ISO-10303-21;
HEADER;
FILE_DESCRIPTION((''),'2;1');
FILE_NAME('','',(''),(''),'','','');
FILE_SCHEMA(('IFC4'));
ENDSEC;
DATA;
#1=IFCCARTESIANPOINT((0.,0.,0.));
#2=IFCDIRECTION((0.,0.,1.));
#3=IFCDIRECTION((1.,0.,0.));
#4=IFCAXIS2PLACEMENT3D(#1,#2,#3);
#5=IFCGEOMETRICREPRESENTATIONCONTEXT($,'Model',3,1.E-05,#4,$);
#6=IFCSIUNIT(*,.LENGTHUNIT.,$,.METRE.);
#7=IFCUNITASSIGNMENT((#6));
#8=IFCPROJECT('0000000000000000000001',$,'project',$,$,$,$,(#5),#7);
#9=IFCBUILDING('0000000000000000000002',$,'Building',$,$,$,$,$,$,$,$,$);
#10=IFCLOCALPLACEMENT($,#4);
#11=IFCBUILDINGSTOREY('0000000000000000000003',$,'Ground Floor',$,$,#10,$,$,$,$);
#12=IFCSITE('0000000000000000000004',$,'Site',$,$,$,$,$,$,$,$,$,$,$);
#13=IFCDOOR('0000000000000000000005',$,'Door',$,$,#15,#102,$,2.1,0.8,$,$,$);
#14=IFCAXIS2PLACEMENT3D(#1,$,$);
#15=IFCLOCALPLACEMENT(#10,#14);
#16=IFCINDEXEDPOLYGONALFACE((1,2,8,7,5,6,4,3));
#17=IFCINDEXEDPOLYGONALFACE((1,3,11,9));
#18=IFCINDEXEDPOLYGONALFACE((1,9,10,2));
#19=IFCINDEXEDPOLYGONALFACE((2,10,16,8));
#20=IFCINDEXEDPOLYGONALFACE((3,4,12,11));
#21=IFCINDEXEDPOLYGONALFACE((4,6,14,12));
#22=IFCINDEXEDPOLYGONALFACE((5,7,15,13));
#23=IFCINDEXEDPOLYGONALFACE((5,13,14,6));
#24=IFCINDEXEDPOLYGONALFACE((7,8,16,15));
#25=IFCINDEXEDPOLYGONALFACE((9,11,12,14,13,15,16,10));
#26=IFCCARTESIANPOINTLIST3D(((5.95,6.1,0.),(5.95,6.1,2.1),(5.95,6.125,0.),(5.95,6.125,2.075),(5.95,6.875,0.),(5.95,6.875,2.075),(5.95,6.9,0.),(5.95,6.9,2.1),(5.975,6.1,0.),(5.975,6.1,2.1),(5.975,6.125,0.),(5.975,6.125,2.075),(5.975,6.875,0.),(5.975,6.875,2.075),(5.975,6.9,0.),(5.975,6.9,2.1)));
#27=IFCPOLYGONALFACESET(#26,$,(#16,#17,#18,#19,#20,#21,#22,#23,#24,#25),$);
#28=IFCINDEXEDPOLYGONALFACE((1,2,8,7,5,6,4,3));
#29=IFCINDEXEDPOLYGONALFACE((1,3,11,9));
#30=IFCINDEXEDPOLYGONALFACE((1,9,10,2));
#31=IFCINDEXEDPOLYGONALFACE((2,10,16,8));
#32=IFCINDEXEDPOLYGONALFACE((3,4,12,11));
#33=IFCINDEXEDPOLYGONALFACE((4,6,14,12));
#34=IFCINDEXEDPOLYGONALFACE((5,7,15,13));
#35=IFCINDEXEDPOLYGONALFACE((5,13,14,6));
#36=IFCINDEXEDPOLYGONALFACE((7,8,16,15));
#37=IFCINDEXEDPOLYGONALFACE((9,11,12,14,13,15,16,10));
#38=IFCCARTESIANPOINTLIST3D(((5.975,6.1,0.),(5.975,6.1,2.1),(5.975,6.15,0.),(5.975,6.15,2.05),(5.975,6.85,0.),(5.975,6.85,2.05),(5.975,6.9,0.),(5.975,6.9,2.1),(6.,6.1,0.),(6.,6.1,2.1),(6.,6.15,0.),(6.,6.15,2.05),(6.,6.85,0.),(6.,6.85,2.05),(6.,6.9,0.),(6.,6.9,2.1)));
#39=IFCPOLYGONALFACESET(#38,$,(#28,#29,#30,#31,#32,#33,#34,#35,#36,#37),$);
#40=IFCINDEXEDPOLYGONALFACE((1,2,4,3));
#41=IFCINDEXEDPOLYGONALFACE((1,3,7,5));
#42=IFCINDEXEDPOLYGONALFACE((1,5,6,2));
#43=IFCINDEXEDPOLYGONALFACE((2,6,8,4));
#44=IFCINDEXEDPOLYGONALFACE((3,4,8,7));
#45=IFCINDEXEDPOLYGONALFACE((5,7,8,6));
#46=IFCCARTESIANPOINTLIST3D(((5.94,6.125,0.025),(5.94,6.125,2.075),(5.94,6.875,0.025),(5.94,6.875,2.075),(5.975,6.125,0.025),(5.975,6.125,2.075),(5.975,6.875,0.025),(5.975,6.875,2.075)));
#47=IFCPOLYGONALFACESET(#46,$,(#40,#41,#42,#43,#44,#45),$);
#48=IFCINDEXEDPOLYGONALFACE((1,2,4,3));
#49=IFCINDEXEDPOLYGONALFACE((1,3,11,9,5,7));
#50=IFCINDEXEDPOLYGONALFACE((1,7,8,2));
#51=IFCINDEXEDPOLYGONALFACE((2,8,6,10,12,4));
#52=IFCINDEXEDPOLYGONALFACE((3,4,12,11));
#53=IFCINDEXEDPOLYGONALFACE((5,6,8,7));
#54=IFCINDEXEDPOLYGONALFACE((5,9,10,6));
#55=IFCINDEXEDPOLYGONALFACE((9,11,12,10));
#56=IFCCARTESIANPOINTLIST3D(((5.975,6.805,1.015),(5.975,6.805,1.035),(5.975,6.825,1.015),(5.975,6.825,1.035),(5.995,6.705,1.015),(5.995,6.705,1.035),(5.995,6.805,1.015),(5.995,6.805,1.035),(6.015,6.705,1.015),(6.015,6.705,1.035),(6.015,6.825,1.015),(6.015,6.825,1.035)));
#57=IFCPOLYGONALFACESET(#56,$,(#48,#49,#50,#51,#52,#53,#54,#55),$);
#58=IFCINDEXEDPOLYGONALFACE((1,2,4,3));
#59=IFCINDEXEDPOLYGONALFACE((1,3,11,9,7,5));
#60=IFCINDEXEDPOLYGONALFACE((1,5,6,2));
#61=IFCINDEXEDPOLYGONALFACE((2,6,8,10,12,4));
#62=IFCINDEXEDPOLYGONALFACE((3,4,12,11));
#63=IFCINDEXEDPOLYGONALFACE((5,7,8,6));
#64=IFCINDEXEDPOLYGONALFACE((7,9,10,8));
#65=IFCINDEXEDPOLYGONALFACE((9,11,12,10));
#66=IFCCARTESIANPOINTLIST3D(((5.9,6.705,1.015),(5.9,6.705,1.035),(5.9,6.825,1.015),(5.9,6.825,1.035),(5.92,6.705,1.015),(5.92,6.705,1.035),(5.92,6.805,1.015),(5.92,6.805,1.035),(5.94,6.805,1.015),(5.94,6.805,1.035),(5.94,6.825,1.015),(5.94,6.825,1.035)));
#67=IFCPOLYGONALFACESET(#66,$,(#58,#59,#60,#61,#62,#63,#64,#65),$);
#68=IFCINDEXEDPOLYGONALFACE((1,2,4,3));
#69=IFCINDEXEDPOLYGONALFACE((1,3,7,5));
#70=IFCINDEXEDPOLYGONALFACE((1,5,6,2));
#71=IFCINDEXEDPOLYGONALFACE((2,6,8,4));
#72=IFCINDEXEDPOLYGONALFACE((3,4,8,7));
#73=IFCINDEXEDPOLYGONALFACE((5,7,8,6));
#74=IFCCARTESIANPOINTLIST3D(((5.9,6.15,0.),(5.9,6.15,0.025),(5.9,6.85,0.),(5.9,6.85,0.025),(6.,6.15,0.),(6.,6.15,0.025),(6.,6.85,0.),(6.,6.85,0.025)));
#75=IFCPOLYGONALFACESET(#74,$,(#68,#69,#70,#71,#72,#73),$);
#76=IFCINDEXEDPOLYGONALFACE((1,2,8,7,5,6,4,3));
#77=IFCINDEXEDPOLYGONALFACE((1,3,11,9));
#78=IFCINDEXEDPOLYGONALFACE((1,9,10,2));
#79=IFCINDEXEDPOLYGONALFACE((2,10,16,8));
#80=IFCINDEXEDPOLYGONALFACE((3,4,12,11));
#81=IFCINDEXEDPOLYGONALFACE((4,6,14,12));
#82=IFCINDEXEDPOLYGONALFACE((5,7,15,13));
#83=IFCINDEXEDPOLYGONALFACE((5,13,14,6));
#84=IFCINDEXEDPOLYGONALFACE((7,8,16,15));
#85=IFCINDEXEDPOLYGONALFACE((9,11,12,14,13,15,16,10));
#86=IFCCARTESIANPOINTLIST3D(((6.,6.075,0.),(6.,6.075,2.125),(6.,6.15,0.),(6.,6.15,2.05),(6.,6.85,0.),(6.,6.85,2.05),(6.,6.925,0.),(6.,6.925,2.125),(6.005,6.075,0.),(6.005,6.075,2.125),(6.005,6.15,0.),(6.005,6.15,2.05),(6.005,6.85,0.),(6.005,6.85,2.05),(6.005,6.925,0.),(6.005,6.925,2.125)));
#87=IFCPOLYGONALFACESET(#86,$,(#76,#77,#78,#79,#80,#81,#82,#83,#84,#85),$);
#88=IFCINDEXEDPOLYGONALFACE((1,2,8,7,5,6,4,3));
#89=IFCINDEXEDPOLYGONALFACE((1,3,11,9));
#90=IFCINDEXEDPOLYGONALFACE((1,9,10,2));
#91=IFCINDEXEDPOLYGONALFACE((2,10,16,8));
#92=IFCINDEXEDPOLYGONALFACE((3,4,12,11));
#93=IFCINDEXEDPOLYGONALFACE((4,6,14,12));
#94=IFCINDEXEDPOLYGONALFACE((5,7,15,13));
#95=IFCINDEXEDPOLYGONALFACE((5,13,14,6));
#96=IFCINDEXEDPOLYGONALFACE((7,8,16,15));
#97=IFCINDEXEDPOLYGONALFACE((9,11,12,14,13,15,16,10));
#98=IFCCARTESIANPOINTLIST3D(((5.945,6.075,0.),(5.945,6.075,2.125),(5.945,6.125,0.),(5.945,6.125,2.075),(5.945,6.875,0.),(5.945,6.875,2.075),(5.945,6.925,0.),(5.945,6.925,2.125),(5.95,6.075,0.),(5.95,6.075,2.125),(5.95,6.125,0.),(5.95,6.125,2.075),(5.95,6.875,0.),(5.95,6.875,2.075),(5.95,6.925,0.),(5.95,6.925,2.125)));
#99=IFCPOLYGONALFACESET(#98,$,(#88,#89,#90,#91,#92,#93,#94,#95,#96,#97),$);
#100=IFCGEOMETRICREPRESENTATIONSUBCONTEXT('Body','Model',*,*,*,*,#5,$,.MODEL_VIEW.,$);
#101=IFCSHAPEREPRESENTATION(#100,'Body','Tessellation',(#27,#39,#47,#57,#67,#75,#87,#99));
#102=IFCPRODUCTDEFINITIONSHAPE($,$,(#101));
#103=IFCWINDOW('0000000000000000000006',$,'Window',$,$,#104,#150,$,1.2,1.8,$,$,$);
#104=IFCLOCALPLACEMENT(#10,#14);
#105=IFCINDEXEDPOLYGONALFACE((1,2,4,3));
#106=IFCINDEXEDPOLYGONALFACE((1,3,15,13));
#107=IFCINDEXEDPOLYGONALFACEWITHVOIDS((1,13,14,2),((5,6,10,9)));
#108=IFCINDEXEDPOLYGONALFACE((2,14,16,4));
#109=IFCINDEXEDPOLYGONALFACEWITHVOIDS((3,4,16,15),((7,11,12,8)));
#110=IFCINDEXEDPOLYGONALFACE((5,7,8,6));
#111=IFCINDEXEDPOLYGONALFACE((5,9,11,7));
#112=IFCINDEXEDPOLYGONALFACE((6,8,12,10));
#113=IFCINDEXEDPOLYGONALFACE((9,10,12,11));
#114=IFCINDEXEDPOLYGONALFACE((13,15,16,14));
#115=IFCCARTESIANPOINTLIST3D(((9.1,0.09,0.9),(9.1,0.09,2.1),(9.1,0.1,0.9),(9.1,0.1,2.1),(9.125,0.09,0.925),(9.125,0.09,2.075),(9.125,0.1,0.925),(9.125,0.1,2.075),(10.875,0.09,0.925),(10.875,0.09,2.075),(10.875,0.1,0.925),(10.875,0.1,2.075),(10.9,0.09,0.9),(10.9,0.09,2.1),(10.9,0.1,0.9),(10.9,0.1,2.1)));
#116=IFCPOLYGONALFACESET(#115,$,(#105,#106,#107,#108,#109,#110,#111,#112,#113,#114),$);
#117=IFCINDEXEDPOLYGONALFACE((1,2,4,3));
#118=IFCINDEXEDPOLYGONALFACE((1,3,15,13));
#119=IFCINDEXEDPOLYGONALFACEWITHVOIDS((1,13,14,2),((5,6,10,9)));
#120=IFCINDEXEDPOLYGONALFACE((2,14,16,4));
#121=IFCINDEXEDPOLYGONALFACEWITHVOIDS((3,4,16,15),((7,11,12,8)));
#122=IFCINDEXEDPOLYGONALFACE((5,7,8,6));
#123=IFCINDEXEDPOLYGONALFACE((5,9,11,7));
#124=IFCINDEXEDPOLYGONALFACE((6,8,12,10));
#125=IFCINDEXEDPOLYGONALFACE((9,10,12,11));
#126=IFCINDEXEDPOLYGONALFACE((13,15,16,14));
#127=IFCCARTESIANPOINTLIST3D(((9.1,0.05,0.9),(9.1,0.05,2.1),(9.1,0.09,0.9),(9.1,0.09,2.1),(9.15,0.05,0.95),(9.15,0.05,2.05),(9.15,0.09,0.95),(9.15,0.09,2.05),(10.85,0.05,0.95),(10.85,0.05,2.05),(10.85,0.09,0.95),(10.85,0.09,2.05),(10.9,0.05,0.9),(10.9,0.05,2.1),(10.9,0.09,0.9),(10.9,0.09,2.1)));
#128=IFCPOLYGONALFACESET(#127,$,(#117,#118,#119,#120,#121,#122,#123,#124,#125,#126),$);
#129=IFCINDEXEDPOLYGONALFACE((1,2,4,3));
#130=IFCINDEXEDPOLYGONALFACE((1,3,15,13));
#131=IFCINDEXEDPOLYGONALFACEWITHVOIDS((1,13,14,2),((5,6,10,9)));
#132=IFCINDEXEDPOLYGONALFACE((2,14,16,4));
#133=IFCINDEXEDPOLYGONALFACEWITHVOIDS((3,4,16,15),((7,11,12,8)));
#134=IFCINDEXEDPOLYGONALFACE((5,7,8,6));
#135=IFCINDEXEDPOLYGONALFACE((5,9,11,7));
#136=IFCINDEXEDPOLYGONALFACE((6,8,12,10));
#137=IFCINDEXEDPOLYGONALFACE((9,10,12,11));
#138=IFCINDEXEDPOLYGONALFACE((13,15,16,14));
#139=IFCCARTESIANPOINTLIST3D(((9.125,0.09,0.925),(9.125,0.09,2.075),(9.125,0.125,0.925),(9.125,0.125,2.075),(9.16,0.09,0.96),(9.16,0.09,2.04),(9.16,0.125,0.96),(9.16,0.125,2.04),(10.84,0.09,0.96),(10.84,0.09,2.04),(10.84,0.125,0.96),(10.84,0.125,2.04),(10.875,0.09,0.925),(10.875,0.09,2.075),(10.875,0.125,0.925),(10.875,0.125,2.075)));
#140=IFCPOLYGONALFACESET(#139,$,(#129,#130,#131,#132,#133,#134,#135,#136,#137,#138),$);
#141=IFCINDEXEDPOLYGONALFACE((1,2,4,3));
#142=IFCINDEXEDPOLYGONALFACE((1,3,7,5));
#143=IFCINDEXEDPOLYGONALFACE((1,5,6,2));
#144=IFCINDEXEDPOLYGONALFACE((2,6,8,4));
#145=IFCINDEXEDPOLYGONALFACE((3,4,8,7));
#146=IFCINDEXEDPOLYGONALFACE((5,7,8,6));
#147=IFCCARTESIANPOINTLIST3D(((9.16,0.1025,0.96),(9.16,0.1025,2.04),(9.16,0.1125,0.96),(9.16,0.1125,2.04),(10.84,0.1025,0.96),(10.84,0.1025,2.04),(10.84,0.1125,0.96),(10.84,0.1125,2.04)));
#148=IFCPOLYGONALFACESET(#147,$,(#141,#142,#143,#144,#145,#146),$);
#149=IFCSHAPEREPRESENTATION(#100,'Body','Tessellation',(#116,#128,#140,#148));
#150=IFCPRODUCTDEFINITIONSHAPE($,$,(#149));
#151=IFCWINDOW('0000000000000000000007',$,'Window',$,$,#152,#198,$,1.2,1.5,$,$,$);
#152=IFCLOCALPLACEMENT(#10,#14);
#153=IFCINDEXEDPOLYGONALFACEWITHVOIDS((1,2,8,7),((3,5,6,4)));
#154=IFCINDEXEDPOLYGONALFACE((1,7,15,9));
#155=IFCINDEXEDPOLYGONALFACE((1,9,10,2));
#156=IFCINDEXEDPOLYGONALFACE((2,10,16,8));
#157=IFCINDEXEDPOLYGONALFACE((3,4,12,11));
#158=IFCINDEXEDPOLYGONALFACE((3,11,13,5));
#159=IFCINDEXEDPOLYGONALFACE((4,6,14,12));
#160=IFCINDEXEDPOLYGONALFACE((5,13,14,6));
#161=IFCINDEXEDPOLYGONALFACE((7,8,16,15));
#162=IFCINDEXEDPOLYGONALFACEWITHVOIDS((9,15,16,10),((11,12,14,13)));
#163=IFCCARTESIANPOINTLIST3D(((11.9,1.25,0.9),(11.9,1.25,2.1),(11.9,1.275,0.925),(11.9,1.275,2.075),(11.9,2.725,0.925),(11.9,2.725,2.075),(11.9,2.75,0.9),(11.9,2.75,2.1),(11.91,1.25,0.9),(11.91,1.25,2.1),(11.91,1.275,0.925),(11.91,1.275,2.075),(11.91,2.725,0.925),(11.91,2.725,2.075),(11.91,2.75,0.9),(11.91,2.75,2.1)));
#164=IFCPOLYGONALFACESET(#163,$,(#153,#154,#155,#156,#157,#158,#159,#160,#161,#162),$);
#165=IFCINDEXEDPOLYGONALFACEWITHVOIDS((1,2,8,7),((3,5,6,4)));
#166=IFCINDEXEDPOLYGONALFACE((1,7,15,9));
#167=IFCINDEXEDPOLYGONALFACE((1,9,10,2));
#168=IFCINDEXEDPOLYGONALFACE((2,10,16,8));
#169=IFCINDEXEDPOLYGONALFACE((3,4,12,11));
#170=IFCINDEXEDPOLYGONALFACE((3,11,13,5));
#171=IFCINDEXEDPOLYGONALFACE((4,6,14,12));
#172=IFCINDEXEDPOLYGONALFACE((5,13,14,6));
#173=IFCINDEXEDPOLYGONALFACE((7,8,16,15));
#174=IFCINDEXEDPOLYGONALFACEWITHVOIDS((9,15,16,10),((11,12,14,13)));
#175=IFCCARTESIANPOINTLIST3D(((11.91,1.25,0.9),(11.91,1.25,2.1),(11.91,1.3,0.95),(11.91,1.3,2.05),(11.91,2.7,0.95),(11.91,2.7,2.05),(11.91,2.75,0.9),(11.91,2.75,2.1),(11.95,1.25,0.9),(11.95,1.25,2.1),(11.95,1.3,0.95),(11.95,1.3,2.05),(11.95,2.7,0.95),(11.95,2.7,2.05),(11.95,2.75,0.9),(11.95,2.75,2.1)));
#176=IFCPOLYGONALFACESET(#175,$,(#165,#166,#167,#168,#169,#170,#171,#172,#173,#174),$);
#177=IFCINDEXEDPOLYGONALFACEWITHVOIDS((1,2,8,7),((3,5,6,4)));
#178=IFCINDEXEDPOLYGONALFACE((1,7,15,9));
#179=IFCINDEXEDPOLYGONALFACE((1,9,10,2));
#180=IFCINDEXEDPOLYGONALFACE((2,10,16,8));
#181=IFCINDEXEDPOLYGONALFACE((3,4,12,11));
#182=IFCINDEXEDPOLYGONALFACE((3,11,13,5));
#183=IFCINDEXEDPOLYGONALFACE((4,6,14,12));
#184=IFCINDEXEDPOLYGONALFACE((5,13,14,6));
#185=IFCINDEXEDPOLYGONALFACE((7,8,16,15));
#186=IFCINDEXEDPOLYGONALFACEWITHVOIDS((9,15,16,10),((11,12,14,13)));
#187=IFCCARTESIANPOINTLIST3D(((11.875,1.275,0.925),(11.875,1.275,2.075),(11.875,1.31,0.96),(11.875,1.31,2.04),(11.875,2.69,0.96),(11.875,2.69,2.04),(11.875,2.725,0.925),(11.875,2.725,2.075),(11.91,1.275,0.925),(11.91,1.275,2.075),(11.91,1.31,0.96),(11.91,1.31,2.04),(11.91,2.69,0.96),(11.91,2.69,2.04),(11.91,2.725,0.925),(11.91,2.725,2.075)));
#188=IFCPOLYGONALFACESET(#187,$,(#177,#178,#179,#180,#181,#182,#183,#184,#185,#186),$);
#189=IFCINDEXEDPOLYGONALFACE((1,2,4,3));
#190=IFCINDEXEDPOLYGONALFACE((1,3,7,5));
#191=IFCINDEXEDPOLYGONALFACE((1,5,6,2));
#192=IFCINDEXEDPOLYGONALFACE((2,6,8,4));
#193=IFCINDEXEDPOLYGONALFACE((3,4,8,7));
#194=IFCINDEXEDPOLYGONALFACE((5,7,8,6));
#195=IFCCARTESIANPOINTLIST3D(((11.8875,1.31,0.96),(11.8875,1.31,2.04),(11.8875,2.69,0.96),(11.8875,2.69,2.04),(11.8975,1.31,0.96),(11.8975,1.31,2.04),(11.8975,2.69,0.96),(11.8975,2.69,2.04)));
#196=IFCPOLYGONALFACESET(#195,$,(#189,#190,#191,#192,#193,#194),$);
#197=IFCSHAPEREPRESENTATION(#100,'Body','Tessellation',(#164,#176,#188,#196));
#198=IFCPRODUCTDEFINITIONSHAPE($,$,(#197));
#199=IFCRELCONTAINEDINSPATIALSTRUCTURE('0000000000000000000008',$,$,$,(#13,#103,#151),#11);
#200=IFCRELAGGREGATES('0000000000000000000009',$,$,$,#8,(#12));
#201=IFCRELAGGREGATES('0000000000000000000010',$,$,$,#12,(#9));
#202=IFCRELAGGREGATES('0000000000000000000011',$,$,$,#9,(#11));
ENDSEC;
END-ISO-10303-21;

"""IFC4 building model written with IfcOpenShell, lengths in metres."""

from ifc_helpers import new_model, si_unit, frame, origin_with_axes, place, context, subcontext, project, spatial, line, indexed_curve, outline, extrude, element, save


model = new_model("IFC4")

# Units and contexts
model_context = context("Model", 3, precision=1e-05, world=origin_with_axes())
body_context = subcontext(model_context, "Body", "Model", "MODEL_VIEW")
ifc_project = project(units=[si_unit("LENGTHUNIT", "METRE")], contexts=[model_context])

# Site, building, storey
site = spatial("IfcSite", under=ifc_project, Name="Site")
building = spatial("IfcBuilding", under=site, Name="Building")
storey_placement = place(None, origin_with_axes())
storey = spatial("IfcBuildingStorey", under=building, at=storey_placement, Name="Ground Floor")

# Door
door_1_placement = place(storey_placement, frame((6.0, 6.1, 0.0), z_axis=(0.0, 0.0, 1.0), x_axis=(0.0, 1.0, 0.0)))
element("IfcDoor", 1, at=door_1_placement, inside=storey, Name="Door", OverallHeight=2.1, OverallWidth=0.8, context=body_context, shape_type="SweptSolid", body=[
    extrude(outline(indexed_curve([(0.0, 0.0), (0.0, 2.1), (0.8, 2.1), (0.8, 0.0), (0.775, 0.0), (0.775, 2.075), (0.025, 2.075), (0.025, 0.0)], segments=[line(1, 2, 3, 4, 5, 6, 7, 8, 1)])), frame((0.0, 0.025, 0.0), z_axis=(0.0, -1.0, 0.0), x_axis=(1.0, 0.0, 0.0)), (0.0, 0.0, -1.0), 0.025),
    extrude(outline(indexed_curve([(0.0, 0.0), (0.0, 2.1), (0.8, 2.1), (0.8, 0.0), (0.75, 0.0), (0.75, 2.05), (0.05, 2.05), (0.05, 0.0)], segments=[line(1, 2, 3, 4, 5, 6, 7, 8, 1)])), frame((0.0, 0.0, 0.0), z_axis=(0.0, -1.0, 0.0), x_axis=(1.0, 0.0, 0.0)), (0.0, 0.0, -1.0), 0.025),
    extrude(outline(indexed_curve([(0.0, 0.0), (0.75, 0.0), (0.75, 0.035), (0.0, 0.035)], segments=[line(1, 2, 3, 4, 1)])), frame((0.025, 0.025, 0.025), z_axis=(0.0, 0.0, 1.0), x_axis=(1.0, 0.0, 0.0)), (0.0, 0.0, 1.0), 2.05),
    extrude(outline(indexed_curve([(0.0, 0.0), (0.0, -0.04), (-0.12, -0.04), (-0.12, -0.02), (-0.02, -0.02), (-0.02, 0.0)], segments=[line(1, 2, 3, 4, 5, 6, 1)])), frame((0.725, 0.025, 1.015), z_axis=(0.0, 0.0, 1.0), x_axis=(1.0, 0.0, 0.0)), (0.0, 0.0, 1.0), 0.02),
    extrude(outline(indexed_curve([(0.0, 0.0), (0.0, 0.04), (-0.12, 0.04), (-0.12, 0.02), (-0.02, 0.02), (-0.02, 0.0)], segments=[line(1, 2, 3, 4, 5, 6, 1)])), frame((0.725, 0.06, 1.015), z_axis=(0.0, 0.0, 1.0), x_axis=(1.0, 0.0, 0.0)), (0.0, 0.0, 1.0), 0.02),
    extrude(outline(indexed_curve([(0.0, 0.0), (0.7, 0.0), (0.7, 0.1), (0.0, 0.1)], segments=[line(1, 2, 3, 4, 1)])), frame((0.05, 0.0, 0.0), z_axis=(0.0, 0.0, 1.0), x_axis=(1.0, 0.0, 0.0)), (0.0, 0.0, 1.0), 0.025),
    extrude(outline(indexed_curve([(0.0, 0.0), (0.0, 2.125), (0.85, 2.125), (0.85, 0.0), (0.775, 0.0), (0.775, 2.05), (0.075, 2.05), (0.075, 0.0)], segments=[line(1, 2, 3, 4, 5, 6, 7, 8, 1)])), frame((-0.025, -0.005, 0.0), z_axis=(0.0, -1.0, 0.0), x_axis=(1.0, 0.0, 0.0)), (0.0, 0.0, -1.0), 0.005),
    extrude(outline(indexed_curve([(0.0, 0.0), (0.0, 2.125), (0.85, 2.125), (0.85, 0.0), (0.8, 0.0), (0.8, 2.075), (0.05, 2.075), (0.05, 0.0)], segments=[line(1, 2, 3, 4, 5, 6, 7, 8, 1)])), frame((-0.025, 0.05, 0.0), z_axis=(0.0, -1.0, 0.0), x_axis=(1.0, 0.0, 0.0)), (0.0, 0.0, -1.0), 0.005),
])

# Windows
window_1_placement = place(storey_placement, frame((9.1, 0.0, 0.9), z_axis=(0.0, 0.0, 1.0), x_axis=(1.0, 0.0, 0.0)))
element("IfcWindow", 2, at=window_1_placement, inside=storey, Name="Window", OverallHeight=1.2, OverallWidth=1.8, context=body_context, shape_type="SweptSolid", body=[
    extrude(outline(indexed_curve([(0.0, 0.0), (1.8, 0.0), (1.8, 1.2), (0.0, 1.2)], segments=[line(1, 2, 3, 4, 1)]), holes=[indexed_curve([(0.025, 0.025), (1.775, 0.025), (1.775, 1.175), (0.025, 1.175)], segments=[line(1, 2, 3, 4, 1)])]), frame((0.0, 0.09, 0.0), z_axis=(0.0, -1.0, 0.0), x_axis=(1.0, 0.0, 0.0)), (0.0, 0.0, -1.0), 0.01),
    extrude(outline(indexed_curve([(0.0, 0.0), (1.8, 0.0), (1.8, 1.2), (0.0, 1.2)], segments=[line(1, 2, 3, 4, 1)]), holes=[indexed_curve([(0.05, 0.05), (1.75, 0.05), (1.75, 1.15), (0.05, 1.15)], segments=[line(1, 2, 3, 4, 1)])]), frame((0.0, 0.05, 0.0), z_axis=(0.0, -1.0, 0.0), x_axis=(1.0, 0.0, 0.0)), (0.0, 0.0, -1.0), 0.04),
    extrude(outline(indexed_curve([(0.0, 0.0), (1.75, 0.0), (1.75, 1.15), (0.0, 1.15)], segments=[line(1, 2, 3, 4, 1)]), holes=[indexed_curve([(0.035, 0.035), (1.715, 0.035), (1.715, 1.115), (0.035, 1.115)], segments=[line(1, 2, 3, 4, 1)])]), frame((0.025, 0.09, 0.025), z_axis=(0.0, -1.0, 0.0), x_axis=(1.0, 0.0, 0.0)), (0.0, 0.0, -1.0), 0.035),
    extrude(outline(indexed_curve([(0.035, 0.035), (1.715, 0.035), (1.715, 1.115), (0.035, 1.115)], segments=[line(1, 2, 3, 4, 1)])), frame((0.025, 0.1025, 0.025), z_axis=(0.0, -1.0, 0.0), x_axis=(1.0, 0.0, 0.0)), (0.0, 0.0, -1.0), 0.01),
])
window_2_placement = place(storey_placement, frame((12.0, 1.25, 0.9), z_axis=(0.0, 0.0, 1.0), x_axis=(0.0, 1.0, 0.0)))
element("IfcWindow", 3, at=window_2_placement, inside=storey, Name="Window", OverallHeight=1.2, OverallWidth=1.5, context=body_context, shape_type="SweptSolid", body=[
    extrude(outline(indexed_curve([(0.0, 0.0), (1.5, 0.0), (1.5, 1.2), (0.0, 1.2)], segments=[line(1, 2, 3, 4, 1)]), holes=[indexed_curve([(0.025, 0.025), (1.475, 0.025), (1.475, 1.175), (0.025, 1.175)], segments=[line(1, 2, 3, 4, 1)])]), frame((0.0, 0.09, 0.0), z_axis=(0.0, -1.0, 0.0), x_axis=(1.0, 0.0, 0.0)), (0.0, 0.0, -1.0), 0.01),
    extrude(outline(indexed_curve([(0.0, 0.0), (1.5, 0.0), (1.5, 1.2), (0.0, 1.2)], segments=[line(1, 2, 3, 4, 1)]), holes=[indexed_curve([(0.05, 0.05), (1.45, 0.05), (1.45, 1.15), (0.05, 1.15)], segments=[line(1, 2, 3, 4, 1)])]), frame((0.0, 0.05, 0.0), z_axis=(0.0, -1.0, 0.0), x_axis=(1.0, 0.0, 0.0)), (0.0, 0.0, -1.0), 0.04),
    extrude(outline(indexed_curve([(0.0, 0.0), (1.45, 0.0), (1.45, 1.15), (0.0, 1.15)], segments=[line(1, 2, 3, 4, 1)]), holes=[indexed_curve([(0.035, 0.035), (1.415, 0.035), (1.415, 1.115), (0.035, 1.115)], segments=[line(1, 2, 3, 4, 1)])]), frame((0.025, 0.09, 0.025), z_axis=(0.0, -1.0, 0.0), x_axis=(1.0, 0.0, 0.0)), (0.0, 0.0, -1.0), 0.035),
    extrude(outline(indexed_curve([(0.035, 0.035), (1.415, 0.035), (1.415, 1.115), (0.035, 1.115)], segments=[line(1, 2, 3, 4, 1)])), frame((0.025, 0.1025, 0.025), z_axis=(0.0, -1.0, 0.0), x_axis=(1.0, 0.0, 0.0)), (0.0, 0.0, -1.0), 0.01),
])

save(model, "model.ifc")
